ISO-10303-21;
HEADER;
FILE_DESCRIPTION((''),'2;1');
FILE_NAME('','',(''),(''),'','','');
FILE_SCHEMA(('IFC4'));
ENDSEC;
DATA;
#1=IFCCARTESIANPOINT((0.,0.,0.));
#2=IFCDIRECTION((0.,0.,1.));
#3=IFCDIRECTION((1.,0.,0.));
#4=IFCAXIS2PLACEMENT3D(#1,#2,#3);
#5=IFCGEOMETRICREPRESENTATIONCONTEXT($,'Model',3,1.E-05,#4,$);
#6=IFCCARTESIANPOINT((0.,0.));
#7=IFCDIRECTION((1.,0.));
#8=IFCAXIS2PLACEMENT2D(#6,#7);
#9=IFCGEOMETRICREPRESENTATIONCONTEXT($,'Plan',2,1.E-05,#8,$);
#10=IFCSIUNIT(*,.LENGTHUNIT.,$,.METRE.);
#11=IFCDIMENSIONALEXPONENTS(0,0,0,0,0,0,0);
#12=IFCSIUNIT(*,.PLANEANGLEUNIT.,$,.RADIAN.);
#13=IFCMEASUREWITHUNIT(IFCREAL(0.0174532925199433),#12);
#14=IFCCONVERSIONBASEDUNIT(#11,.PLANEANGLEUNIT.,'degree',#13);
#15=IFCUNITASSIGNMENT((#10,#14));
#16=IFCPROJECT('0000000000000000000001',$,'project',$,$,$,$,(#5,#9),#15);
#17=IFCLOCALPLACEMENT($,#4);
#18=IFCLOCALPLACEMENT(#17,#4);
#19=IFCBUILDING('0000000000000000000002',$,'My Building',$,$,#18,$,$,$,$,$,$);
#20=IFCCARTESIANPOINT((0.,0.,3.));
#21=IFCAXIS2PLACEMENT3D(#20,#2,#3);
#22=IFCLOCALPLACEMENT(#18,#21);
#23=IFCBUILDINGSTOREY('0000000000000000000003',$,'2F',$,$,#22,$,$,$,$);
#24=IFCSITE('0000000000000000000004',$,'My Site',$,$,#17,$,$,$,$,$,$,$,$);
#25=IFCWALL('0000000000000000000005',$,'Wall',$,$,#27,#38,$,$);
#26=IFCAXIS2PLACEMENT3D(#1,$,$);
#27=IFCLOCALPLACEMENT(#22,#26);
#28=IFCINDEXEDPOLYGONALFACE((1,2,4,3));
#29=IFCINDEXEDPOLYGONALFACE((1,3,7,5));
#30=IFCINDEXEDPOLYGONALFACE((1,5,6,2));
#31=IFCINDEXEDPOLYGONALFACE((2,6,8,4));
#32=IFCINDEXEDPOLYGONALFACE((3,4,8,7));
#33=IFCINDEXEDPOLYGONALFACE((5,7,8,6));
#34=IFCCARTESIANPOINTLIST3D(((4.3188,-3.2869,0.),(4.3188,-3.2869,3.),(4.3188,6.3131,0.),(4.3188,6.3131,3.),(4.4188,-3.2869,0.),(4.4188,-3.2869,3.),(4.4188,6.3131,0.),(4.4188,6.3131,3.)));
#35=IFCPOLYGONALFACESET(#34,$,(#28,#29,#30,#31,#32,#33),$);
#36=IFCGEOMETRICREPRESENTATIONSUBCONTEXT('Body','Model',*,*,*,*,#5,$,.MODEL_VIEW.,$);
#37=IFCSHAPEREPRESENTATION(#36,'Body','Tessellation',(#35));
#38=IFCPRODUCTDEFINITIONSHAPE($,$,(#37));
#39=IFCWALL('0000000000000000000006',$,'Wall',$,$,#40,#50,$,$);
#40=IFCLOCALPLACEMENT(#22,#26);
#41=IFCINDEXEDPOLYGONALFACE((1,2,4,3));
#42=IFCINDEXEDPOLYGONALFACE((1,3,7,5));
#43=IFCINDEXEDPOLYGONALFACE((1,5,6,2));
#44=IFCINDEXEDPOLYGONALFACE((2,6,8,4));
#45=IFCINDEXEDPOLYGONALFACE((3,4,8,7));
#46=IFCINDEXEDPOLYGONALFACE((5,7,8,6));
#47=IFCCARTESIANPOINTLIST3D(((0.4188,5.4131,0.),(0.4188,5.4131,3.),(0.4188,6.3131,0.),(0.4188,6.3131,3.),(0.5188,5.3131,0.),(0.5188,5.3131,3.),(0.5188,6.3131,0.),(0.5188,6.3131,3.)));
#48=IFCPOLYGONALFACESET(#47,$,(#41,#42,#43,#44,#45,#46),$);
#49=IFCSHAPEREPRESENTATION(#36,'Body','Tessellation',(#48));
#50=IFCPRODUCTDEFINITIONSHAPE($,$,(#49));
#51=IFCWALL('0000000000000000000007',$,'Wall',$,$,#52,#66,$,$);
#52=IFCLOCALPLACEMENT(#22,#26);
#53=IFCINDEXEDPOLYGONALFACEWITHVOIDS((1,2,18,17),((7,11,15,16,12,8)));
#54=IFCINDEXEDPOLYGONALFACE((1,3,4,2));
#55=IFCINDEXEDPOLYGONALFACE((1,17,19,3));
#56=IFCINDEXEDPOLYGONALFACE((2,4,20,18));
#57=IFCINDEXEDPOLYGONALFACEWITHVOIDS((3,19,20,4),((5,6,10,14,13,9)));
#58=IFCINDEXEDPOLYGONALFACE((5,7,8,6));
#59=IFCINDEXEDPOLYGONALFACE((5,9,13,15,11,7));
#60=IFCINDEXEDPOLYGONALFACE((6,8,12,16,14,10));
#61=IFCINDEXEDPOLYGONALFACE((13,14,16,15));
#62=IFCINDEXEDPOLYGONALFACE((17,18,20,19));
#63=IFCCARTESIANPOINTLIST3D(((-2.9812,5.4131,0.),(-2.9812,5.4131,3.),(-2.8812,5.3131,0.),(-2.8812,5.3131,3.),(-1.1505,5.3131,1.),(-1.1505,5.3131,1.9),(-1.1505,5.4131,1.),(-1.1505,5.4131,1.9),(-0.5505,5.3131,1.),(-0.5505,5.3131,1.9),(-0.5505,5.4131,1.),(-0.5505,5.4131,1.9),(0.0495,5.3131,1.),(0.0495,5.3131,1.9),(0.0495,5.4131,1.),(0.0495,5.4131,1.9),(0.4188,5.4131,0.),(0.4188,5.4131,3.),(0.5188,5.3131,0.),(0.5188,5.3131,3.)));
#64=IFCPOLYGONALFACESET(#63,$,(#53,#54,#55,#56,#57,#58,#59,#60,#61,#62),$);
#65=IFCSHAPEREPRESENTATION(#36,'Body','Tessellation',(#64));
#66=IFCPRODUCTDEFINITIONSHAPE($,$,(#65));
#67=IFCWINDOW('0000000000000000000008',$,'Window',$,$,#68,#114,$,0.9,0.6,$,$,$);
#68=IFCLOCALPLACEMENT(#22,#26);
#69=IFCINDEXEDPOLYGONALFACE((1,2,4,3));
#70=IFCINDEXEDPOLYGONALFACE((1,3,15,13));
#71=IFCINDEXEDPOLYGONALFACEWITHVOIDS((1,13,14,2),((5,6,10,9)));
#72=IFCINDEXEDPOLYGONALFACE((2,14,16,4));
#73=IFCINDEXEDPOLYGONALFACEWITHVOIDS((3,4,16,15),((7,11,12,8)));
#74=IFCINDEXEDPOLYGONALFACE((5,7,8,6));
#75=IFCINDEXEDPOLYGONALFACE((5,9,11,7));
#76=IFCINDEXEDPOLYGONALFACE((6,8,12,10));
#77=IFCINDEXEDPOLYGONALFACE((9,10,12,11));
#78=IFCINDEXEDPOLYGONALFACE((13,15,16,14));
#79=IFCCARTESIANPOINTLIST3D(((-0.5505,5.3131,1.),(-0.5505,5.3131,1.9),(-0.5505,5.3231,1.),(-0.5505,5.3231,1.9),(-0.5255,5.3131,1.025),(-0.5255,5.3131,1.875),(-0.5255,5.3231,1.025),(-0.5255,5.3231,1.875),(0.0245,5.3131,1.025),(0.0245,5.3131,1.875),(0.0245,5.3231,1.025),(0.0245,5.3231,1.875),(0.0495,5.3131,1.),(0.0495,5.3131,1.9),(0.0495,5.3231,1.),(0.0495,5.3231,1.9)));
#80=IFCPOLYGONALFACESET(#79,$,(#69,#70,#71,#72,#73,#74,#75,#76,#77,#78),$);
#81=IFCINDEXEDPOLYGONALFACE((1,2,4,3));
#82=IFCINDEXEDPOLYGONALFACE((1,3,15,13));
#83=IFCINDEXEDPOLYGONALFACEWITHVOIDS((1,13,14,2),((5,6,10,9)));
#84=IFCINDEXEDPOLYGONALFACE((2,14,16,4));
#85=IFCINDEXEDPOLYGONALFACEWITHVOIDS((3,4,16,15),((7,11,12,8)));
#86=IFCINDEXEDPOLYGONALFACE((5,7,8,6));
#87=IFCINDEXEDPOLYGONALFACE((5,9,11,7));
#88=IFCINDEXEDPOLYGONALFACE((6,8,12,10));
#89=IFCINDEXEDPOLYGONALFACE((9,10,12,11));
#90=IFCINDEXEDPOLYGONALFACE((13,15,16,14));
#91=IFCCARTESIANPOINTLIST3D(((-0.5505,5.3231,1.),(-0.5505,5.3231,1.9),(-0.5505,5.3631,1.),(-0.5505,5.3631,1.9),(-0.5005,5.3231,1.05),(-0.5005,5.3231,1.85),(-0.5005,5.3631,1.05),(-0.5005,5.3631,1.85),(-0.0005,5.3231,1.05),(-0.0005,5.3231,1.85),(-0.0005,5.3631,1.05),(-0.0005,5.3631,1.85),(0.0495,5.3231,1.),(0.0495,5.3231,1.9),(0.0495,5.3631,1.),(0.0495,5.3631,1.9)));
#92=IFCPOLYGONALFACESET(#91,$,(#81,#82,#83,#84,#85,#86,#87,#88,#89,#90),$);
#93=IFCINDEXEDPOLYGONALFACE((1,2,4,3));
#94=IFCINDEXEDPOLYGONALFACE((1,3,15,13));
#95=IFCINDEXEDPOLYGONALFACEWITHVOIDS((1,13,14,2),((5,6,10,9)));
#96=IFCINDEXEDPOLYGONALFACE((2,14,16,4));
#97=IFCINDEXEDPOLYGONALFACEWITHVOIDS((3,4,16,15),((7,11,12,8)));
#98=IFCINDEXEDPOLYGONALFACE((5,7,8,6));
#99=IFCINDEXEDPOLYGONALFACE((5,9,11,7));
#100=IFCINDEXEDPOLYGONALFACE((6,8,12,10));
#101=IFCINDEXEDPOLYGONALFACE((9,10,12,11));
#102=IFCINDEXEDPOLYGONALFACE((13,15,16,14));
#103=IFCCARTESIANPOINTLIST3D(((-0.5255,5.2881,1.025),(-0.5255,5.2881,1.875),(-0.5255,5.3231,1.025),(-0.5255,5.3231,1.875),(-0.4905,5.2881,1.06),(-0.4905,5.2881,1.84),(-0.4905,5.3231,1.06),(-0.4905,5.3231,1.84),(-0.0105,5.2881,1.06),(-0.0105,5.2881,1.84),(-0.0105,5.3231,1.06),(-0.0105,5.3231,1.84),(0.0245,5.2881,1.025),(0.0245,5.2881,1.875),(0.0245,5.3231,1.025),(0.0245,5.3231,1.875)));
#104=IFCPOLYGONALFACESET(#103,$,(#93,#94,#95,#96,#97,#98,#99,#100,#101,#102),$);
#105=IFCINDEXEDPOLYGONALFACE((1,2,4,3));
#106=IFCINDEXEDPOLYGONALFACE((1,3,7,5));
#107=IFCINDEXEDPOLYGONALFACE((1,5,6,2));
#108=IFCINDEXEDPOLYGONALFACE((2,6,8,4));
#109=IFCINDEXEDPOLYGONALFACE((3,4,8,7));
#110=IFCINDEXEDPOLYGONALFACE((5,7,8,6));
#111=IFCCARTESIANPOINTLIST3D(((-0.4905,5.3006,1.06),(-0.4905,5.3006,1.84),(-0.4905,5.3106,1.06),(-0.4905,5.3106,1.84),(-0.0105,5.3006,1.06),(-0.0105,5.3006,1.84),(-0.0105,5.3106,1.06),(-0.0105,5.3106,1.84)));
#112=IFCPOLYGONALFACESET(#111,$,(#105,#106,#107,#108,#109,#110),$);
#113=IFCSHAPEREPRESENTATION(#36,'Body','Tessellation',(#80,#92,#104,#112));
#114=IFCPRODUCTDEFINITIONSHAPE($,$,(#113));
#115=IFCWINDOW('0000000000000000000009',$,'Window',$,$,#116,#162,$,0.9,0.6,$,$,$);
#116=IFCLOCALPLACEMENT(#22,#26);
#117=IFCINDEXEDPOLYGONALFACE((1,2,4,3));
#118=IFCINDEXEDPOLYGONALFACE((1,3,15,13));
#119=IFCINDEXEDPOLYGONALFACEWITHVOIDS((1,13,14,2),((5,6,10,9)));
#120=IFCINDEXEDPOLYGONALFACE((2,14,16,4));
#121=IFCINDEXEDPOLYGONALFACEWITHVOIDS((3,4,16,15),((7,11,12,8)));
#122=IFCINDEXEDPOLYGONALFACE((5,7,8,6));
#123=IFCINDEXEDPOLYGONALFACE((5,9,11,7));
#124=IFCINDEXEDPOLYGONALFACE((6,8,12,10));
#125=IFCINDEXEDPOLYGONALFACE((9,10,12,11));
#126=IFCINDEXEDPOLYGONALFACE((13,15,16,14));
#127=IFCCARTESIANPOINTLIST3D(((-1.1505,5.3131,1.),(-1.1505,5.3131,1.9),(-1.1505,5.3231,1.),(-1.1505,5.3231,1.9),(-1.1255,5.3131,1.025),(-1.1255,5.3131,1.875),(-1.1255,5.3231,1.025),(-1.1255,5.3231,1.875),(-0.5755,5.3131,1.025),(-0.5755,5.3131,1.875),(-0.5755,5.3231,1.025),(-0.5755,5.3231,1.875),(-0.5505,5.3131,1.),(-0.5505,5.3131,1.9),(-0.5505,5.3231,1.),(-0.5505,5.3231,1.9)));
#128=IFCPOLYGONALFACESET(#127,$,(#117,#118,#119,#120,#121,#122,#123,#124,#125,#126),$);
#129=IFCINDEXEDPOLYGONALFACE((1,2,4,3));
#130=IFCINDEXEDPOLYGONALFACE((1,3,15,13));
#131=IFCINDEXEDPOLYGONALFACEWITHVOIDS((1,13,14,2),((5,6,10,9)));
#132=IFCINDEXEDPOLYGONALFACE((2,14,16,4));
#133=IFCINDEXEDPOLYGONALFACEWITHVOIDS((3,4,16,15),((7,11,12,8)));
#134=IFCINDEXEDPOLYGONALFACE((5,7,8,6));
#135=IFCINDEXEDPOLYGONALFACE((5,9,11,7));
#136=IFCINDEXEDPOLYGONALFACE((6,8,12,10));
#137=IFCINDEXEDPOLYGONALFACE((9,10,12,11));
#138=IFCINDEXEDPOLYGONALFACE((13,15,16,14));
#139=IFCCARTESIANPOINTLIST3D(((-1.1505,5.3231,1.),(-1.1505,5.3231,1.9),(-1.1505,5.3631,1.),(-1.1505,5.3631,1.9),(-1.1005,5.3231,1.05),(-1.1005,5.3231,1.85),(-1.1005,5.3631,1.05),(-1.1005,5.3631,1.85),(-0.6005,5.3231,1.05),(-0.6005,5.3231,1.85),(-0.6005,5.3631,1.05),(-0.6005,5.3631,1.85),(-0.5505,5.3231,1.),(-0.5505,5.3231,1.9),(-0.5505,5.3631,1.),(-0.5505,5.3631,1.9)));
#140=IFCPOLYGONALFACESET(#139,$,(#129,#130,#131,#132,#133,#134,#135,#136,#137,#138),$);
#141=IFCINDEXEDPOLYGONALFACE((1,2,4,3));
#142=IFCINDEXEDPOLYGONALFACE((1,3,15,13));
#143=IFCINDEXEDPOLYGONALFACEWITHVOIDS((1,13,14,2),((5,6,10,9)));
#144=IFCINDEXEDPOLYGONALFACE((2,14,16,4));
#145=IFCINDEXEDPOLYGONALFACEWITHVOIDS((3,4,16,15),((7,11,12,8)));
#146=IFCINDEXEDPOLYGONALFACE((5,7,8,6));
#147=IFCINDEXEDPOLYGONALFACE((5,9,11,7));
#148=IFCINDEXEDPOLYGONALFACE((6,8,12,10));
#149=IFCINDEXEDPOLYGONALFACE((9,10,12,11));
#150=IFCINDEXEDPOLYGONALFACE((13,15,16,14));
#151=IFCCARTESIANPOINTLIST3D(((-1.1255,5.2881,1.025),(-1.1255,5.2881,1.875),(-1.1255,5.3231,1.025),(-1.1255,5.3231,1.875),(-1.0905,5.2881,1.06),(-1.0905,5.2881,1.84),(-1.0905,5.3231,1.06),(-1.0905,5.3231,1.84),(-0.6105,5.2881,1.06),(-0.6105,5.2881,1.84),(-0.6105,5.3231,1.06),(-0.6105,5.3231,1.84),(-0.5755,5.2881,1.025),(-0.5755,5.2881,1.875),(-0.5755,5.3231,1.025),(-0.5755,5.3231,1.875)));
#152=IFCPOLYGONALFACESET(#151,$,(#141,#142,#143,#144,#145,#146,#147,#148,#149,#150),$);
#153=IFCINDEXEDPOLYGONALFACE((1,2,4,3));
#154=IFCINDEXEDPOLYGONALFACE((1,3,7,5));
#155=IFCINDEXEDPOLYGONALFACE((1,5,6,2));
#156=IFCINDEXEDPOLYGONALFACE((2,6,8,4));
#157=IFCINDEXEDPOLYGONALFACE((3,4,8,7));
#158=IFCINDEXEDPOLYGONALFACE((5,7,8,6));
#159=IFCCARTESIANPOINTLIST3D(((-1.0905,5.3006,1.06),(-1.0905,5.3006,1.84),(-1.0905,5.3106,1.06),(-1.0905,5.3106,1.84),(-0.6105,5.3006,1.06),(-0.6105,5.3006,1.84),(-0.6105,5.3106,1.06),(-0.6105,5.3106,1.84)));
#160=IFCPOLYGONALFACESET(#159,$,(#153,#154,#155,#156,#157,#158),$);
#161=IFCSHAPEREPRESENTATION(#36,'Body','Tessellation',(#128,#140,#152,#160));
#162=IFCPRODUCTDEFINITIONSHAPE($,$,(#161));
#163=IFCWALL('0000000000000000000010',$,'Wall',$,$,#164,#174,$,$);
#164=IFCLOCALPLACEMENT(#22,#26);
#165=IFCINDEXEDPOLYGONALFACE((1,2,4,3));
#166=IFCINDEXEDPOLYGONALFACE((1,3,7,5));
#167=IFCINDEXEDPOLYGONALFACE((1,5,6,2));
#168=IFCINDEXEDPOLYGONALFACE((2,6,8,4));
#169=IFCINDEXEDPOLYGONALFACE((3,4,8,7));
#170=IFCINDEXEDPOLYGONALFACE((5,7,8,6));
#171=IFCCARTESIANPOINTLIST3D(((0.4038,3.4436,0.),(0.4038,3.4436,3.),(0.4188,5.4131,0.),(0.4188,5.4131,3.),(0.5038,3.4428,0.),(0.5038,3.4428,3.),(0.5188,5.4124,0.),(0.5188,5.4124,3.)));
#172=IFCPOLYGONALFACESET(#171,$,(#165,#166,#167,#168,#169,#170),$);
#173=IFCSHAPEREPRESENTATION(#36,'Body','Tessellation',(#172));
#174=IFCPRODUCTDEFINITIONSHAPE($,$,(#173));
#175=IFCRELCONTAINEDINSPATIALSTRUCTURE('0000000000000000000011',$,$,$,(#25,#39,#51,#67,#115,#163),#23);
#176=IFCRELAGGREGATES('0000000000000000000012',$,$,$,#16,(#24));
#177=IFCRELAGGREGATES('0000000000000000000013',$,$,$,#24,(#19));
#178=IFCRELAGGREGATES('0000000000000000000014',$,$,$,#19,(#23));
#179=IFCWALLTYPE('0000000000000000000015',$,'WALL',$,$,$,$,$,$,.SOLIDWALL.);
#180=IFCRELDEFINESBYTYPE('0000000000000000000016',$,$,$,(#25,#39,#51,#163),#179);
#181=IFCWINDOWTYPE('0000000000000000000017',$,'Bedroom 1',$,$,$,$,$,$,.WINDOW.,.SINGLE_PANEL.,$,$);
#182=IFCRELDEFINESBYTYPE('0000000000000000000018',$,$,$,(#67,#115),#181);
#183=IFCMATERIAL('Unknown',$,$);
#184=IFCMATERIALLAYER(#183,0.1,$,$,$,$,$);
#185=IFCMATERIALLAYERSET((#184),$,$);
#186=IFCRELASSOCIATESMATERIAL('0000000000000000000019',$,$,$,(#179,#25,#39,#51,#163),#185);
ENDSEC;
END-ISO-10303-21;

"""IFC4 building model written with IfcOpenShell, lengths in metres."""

from ifc_helpers import new_model, entity, si_unit, converted_unit, frame, origin_with_axes, origin_2d_with_axis, place, context, subcontext, project, spatial, line, indexed_curve, outline, extrude, shape, source, transform, mapped, material, layer, layer_set, layer_usage, type_object, type_shapes, element, fill, save


model = new_model("IFC4")

# Units and contexts
model_context = context("Model", 3, precision=1e-05, world=origin_with_axes())
plan_context = context("Plan", 2, precision=1e-05, world=origin_2d_with_axis())
body_context_1 = subcontext(model_context, "Body", "Model", "MODEL_VIEW")
body_context_2 = subcontext(plan_context, "Body", "Plan", "PLAN_VIEW")
ifc_project = project(units=[si_unit("LENGTHUNIT", "METRE"), converted_unit("PLANEANGLEUNIT", "degree", entity("IfcReal", 0.0174532925199433), si_unit("PLANEANGLEUNIT", "RADIAN"), dimensions=[0, 0, 0, 0, 0, 0, 0])], contexts=[model_context, plan_context])

# Site, building, storey
site_placement = place(None, origin_with_axes())
site = spatial("IfcSite", under=ifc_project, at=site_placement, Name="My Site")
building_placement = place(site_placement, origin_with_axes())
building = spatial("IfcBuilding", under=site, at=building_placement, Name="My Building")
storey_placement = place(building_placement, frame((0.0, 0.0, 3.0), z_axis=(0.0, 0.0, 1.0), x_axis=(1.0, 0.0, 0.0)))
storey = spatial("IfcBuildingStorey", under=building, at=storey_placement, Name="2F")

# Shared definitions
ifc_material = material(Name="Unknown")

# Walls
ifc_layer_1 = layer(ifc_material, 0.1)
ifc_layer_set_1 = layer_set([ifc_layer_1])
wall_type = type_object("IfcWallType", Name="WALL", PredefinedType="SOLIDWALL", material=ifc_layer_set_1)
ifc_layer_usage_1 = layer_usage(ifc_layer_set_1, "AXIS2", "POSITIVE", 0.0)
wall_1_placement = place(storey_placement, frame((4.3188, 6.3131, 0.0), z_axis=(0.0, 0.0, 1.0), x_axis=(0.0, -1.0, 0.0)))
element("IfcWall", 1, at=wall_1_placement, inside=storey, type_object=wall_type, material=ifc_layer_usage_1, Name="Wall", context=body_context_1, shape_type="SweptSolid", body=[
    extrude(outline(indexed_curve([(0.0, 0.0), (0.0, 0.1), (9.6, 0.1), (9.6, 0.0)], segments=[line(1, 2, 3, 4, 1)])), origin_with_axes(), (0.0, 0.0, 1.0), 3.0),
])
ifc_layer_usage_2 = layer_usage(ifc_layer_set_1, "AXIS2", "POSITIVE", 0.0)
wall_2_placement = place(storey_placement, frame((0.4188, 6.3131, 0.0), z_axis=(0.0, 0.0, 1.0), x_axis=(0.0, -1.0, 0.0)))
element("IfcWall", 2, at=wall_2_placement, inside=storey, type_object=wall_type, material=ifc_layer_usage_2, Name="Wall", context=body_context_1, shape_type="SweptSolid", body=[
    extrude(outline(indexed_curve([(0.0, 0.0), (0.0, 0.1), (1.0, 0.1), (0.9, 0.0)], segments=[line(1, 2, 3, 4, 1)])), origin_with_axes(), (0.0, 0.0, 1.0), 3.0),
])

# Wall, openings, windows
ifc_layer_usage_3 = layer_usage(ifc_layer_set_1, "AXIS2", "POSITIVE", 0.0)
wall_3_placement = place(storey_placement, frame((0.4188, 5.4131, 0.0), z_axis=(0.0, 0.0, 1.0), x_axis=(-1.0, 0.0, 0.0)))
wall_3 = element("IfcWall", 3, at=wall_3_placement, inside=storey, type_object=wall_type, material=ifc_layer_usage_3, Name="Wall", context=body_context_1, shape_type="SweptSolid", body=[
    extrude(outline(indexed_curve([(0.0, 0.0), (-0.1, 0.1), (3.3, 0.1), (3.4, 0.0)], segments=[line(1, 2, 3, 4, 1)])), origin_with_axes(), (0.0, 0.0, 1.0), 3.0),
])
shared_shape_1 = source(origin_with_axes(), body_context_1, "Body", "SweptSolid", [
    extrude(outline(indexed_curve([(0.0, 0.0), (0.6, 0.0), (0.6, 0.9), (0.0, 0.9)], segments=[line(1, 2, 3, 4, 1)])), frame((0.0, -0.6, 0.0), z_axis=(0.0, -1.0, 0.0), x_axis=(1.0, 0.0, 0.0)), (0.0, 0.0, -1.0), 1.2),
])
opening_1_placement = place(wall_3_placement, frame((0.3694, 0.0, 1.0), z_axis=(0.0, 0.0, 1.0), x_axis=(1.0, 0.0, 0.0)))
opening_1 = element("IfcOpeningElement", 4, at=opening_1_placement, cuts=wall_3, PredefinedType="OPENING", context=body_context_1, shape_type="MappedRepresentation", body=[
    mapped(shared_shape_1, transform((0.0, 0.0, 0.0), x_axis=(1.0, 0.0, 0.0), y_axis=(0.0, 1.0, 0.0), z_axis=(0.0, 0.0, 1.0), scale=1.0)),
])
opening_2_placement = place(wall_3_placement, frame((0.9694, 0.0, 1.0), z_axis=(0.0, 0.0, 1.0), x_axis=(1.0, 0.0, 0.0)))
opening_2 = element("IfcOpeningElement", 5, at=opening_2_placement, cuts=wall_3, PredefinedType="OPENING", context=body_context_1, shape_type="MappedRepresentation", body=[
    mapped(shared_shape_1, transform((0.0, 0.0, 0.0), x_axis=(1.0, 0.0, 0.0), y_axis=(0.0, 1.0, 0.0), z_axis=(0.0, 0.0, 1.0), scale=1.0)),
])
window_type_1 = type_object("IfcWindowType", Name="Bedroom 1", PartitioningType="SINGLE_PANEL", PredefinedType="WINDOW")
shared_shape_2 = source(origin_with_axes(), body_context_1, "Body", "SweptSolid", [
    extrude(outline(indexed_curve([(0.0, 0.0), (0.6, 0.0), (0.6, 0.9), (0.0, 0.9)], segments=[line(1, 2, 3, 4, 1)]), holes=[indexed_curve([(0.025, 0.025), (0.575, 0.025), (0.575, 0.875), (0.025, 0.875)], segments=[line(1, 2, 3, 4, 1)])]), frame((0.0, 0.09, 0.0), z_axis=(0.0, -1.0, 0.0), x_axis=(1.0, 0.0, 0.0)), (0.0, 0.0, -1.0), 0.01),
    extrude(outline(indexed_curve([(0.0, 0.0), (0.6, 0.0), (0.6, 0.9), (0.0, 0.9)], segments=[line(1, 2, 3, 4, 1)]), holes=[indexed_curve([(0.05, 0.05), (0.55, 0.05), (0.55, 0.85), (0.05, 0.85)], segments=[line(1, 2, 3, 4, 1)])]), frame((0.0, 0.05, 0.0), z_axis=(0.0, -1.0, 0.0), x_axis=(1.0, 0.0, 0.0)), (0.0, 0.0, -1.0), 0.04),
    extrude(outline(indexed_curve([(0.0, 0.0), (0.55, 0.0), (0.55, 0.85), (0.0, 0.85)], segments=[line(1, 2, 3, 4, 1)]), holes=[indexed_curve([(0.035, 0.035), (0.515, 0.035), (0.515, 0.815), (0.035, 0.815)], segments=[line(1, 2, 3, 4, 1)])]), frame((0.025, 0.09, 0.025), z_axis=(0.0, -1.0, 0.0), x_axis=(1.0, 0.0, 0.0)), (0.0, 0.0, -1.0), 0.035),
    extrude(outline(indexed_curve([(0.035, 0.035), (0.515, 0.035), (0.515, 0.815), (0.035, 0.815)], segments=[line(1, 2, 3, 4, 1)])), frame((0.025, 0.1025, 0.025), z_axis=(0.0, -1.0, 0.0), x_axis=(1.0, 0.0, 0.0)), (0.0, 0.0, -1.0), 0.01),
])
shared_shape_3 = source(origin_with_axes(), body_context_2, "Body", "Curve2D", [
    entity("IfcIndexedPolyCurve", entity("IfcCartesianPointList2D", [[0.05, 0.05], [0.55, 0.05]])),
    entity("IfcIndexedPolyCurve", entity("IfcCartesianPointList2D", [[0.0, 0.1], [0.025, 0.1], [0.025, 0.09], [0.05, 0.09], [0.05, 0.05], [0.0, 0.05]]), [entity("IfcLineIndex", [1, 2, 3, 4, 5, 6, 1])]),
    entity("IfcIndexedPolyCurve", entity("IfcCartesianPointList2D", [[0.6, 0.1], [0.575, 0.1], [0.575, 0.09], [0.55, 0.09], [0.55, 0.05], [0.6, 0.05]]), [entity("IfcLineIndex", [1, 2, 3, 4, 5, 6, 1])]),
    entity("IfcIndexedPolyCurve", entity("IfcCartesianPointList2D", [[0.025, 0.09], [0.06, 0.09], [0.06, 0.125], [0.025, 0.125]]), [entity("IfcLineIndex", [1, 2, 3, 4, 1])]),
    entity("IfcIndexedPolyCurve", entity("IfcCartesianPointList2D", [[0.575, 0.09], [0.54, 0.09], [0.54, 0.125], [0.575, 0.125]]), [entity("IfcLineIndex", [1, 2, 3, 4, 1])]),
    entity("IfcIndexedPolyCurve", entity("IfcCartesianPointList2D", [[0.06, 0.09], [0.54, 0.09]])),
    entity("IfcIndexedPolyCurve", entity("IfcCartesianPointList2D", [[0.06, 0.125], [0.54, 0.125]])),
    entity("IfcIndexedPolyCurve", entity("IfcCartesianPointList2D", [[0.06, 0.1075], [0.54, 0.1075]])),
])
type_shapes(window_type_1, [shared_shape_2, shared_shape_3])
window_1_placement = place(opening_1_placement, frame((0.0, 0.0, 0.0), z_axis=(0.0, 0.0, 1.0), x_axis=(1.0, 0.0, 0.0)))
window_1 = element("IfcWindow", 6, at=window_1_placement, inside=storey, type_object=window_type_1, Name="Window", OverallHeight=0.9, OverallWidth=0.6, shapes=[
    shape(body_context_1, "Body", "MappedRepresentation", [mapped(shared_shape_2, transform((0.0, 0.0, 0.0), x_axis=(1.0, 0.0, 0.0), y_axis=(0.0, 1.0, 0.0), z_axis=(0.0, 0.0, 1.0), scale=1.0))]),
    shape(body_context_2, "Body", "MappedRepresentation", [mapped(shared_shape_3, transform((0.0, 0.0, 0.0), x_axis=(1.0, 0.0, 0.0), y_axis=(0.0, 1.0, 0.0), z_axis=(0.0, 0.0, 1.0), scale=1.0))]),
])
fill(opening_1, window_1)
window_2_placement = place(opening_2_placement, origin_with_axes())
window_2 = element("IfcWindow", 7, at=window_2_placement, inside=storey, type_object=window_type_1, Name="Window", OverallHeight=0.9, OverallWidth=0.6, shapes=[
    shape(body_context_1, "Body", "MappedRepresentation", [mapped(shared_shape_2, transform((0.0, 0.0, 0.0), x_axis=(1.0, 0.0, 0.0), y_axis=(0.0, 1.0, 0.0), z_axis=(0.0, 0.0, 1.0), scale=1.0))]),
    shape(body_context_2, "Body", "MappedRepresentation", [mapped(shared_shape_3, transform((0.0, 0.0, 0.0), x_axis=(1.0, 0.0, 0.0), y_axis=(0.0, 1.0, 0.0), z_axis=(0.0, 0.0, 1.0), scale=1.0))]),
])
fill(opening_2, window_2)

# Wall
ifc_layer_usage_4 = layer_usage(ifc_layer_set_1, "AXIS2", "POSITIVE", 0.0)
wall_4_placement = place(storey_placement, frame((0.4188, 5.4131, 0.0), z_axis=(0.0, 0.0, 1.0), x_axis=(-0.007642, -0.999971, 0.0)))
element("IfcWall", 8, at=wall_4_placement, inside=storey, type_object=wall_type, material=ifc_layer_usage_4, Name="Wall", context=body_context_1, shape_type="SweptSolid", body=[
    extrude(outline(indexed_curve([(0.0, 0.0), (0.0, 0.1), (1.9696, 0.1), (1.9696, 0.0)], segments=[line(1, 2, 3, 4, 1)])), origin_with_axes(), (0.0, 0.0, 1.0), 3.0),
])

save(model, "model.ifc")
